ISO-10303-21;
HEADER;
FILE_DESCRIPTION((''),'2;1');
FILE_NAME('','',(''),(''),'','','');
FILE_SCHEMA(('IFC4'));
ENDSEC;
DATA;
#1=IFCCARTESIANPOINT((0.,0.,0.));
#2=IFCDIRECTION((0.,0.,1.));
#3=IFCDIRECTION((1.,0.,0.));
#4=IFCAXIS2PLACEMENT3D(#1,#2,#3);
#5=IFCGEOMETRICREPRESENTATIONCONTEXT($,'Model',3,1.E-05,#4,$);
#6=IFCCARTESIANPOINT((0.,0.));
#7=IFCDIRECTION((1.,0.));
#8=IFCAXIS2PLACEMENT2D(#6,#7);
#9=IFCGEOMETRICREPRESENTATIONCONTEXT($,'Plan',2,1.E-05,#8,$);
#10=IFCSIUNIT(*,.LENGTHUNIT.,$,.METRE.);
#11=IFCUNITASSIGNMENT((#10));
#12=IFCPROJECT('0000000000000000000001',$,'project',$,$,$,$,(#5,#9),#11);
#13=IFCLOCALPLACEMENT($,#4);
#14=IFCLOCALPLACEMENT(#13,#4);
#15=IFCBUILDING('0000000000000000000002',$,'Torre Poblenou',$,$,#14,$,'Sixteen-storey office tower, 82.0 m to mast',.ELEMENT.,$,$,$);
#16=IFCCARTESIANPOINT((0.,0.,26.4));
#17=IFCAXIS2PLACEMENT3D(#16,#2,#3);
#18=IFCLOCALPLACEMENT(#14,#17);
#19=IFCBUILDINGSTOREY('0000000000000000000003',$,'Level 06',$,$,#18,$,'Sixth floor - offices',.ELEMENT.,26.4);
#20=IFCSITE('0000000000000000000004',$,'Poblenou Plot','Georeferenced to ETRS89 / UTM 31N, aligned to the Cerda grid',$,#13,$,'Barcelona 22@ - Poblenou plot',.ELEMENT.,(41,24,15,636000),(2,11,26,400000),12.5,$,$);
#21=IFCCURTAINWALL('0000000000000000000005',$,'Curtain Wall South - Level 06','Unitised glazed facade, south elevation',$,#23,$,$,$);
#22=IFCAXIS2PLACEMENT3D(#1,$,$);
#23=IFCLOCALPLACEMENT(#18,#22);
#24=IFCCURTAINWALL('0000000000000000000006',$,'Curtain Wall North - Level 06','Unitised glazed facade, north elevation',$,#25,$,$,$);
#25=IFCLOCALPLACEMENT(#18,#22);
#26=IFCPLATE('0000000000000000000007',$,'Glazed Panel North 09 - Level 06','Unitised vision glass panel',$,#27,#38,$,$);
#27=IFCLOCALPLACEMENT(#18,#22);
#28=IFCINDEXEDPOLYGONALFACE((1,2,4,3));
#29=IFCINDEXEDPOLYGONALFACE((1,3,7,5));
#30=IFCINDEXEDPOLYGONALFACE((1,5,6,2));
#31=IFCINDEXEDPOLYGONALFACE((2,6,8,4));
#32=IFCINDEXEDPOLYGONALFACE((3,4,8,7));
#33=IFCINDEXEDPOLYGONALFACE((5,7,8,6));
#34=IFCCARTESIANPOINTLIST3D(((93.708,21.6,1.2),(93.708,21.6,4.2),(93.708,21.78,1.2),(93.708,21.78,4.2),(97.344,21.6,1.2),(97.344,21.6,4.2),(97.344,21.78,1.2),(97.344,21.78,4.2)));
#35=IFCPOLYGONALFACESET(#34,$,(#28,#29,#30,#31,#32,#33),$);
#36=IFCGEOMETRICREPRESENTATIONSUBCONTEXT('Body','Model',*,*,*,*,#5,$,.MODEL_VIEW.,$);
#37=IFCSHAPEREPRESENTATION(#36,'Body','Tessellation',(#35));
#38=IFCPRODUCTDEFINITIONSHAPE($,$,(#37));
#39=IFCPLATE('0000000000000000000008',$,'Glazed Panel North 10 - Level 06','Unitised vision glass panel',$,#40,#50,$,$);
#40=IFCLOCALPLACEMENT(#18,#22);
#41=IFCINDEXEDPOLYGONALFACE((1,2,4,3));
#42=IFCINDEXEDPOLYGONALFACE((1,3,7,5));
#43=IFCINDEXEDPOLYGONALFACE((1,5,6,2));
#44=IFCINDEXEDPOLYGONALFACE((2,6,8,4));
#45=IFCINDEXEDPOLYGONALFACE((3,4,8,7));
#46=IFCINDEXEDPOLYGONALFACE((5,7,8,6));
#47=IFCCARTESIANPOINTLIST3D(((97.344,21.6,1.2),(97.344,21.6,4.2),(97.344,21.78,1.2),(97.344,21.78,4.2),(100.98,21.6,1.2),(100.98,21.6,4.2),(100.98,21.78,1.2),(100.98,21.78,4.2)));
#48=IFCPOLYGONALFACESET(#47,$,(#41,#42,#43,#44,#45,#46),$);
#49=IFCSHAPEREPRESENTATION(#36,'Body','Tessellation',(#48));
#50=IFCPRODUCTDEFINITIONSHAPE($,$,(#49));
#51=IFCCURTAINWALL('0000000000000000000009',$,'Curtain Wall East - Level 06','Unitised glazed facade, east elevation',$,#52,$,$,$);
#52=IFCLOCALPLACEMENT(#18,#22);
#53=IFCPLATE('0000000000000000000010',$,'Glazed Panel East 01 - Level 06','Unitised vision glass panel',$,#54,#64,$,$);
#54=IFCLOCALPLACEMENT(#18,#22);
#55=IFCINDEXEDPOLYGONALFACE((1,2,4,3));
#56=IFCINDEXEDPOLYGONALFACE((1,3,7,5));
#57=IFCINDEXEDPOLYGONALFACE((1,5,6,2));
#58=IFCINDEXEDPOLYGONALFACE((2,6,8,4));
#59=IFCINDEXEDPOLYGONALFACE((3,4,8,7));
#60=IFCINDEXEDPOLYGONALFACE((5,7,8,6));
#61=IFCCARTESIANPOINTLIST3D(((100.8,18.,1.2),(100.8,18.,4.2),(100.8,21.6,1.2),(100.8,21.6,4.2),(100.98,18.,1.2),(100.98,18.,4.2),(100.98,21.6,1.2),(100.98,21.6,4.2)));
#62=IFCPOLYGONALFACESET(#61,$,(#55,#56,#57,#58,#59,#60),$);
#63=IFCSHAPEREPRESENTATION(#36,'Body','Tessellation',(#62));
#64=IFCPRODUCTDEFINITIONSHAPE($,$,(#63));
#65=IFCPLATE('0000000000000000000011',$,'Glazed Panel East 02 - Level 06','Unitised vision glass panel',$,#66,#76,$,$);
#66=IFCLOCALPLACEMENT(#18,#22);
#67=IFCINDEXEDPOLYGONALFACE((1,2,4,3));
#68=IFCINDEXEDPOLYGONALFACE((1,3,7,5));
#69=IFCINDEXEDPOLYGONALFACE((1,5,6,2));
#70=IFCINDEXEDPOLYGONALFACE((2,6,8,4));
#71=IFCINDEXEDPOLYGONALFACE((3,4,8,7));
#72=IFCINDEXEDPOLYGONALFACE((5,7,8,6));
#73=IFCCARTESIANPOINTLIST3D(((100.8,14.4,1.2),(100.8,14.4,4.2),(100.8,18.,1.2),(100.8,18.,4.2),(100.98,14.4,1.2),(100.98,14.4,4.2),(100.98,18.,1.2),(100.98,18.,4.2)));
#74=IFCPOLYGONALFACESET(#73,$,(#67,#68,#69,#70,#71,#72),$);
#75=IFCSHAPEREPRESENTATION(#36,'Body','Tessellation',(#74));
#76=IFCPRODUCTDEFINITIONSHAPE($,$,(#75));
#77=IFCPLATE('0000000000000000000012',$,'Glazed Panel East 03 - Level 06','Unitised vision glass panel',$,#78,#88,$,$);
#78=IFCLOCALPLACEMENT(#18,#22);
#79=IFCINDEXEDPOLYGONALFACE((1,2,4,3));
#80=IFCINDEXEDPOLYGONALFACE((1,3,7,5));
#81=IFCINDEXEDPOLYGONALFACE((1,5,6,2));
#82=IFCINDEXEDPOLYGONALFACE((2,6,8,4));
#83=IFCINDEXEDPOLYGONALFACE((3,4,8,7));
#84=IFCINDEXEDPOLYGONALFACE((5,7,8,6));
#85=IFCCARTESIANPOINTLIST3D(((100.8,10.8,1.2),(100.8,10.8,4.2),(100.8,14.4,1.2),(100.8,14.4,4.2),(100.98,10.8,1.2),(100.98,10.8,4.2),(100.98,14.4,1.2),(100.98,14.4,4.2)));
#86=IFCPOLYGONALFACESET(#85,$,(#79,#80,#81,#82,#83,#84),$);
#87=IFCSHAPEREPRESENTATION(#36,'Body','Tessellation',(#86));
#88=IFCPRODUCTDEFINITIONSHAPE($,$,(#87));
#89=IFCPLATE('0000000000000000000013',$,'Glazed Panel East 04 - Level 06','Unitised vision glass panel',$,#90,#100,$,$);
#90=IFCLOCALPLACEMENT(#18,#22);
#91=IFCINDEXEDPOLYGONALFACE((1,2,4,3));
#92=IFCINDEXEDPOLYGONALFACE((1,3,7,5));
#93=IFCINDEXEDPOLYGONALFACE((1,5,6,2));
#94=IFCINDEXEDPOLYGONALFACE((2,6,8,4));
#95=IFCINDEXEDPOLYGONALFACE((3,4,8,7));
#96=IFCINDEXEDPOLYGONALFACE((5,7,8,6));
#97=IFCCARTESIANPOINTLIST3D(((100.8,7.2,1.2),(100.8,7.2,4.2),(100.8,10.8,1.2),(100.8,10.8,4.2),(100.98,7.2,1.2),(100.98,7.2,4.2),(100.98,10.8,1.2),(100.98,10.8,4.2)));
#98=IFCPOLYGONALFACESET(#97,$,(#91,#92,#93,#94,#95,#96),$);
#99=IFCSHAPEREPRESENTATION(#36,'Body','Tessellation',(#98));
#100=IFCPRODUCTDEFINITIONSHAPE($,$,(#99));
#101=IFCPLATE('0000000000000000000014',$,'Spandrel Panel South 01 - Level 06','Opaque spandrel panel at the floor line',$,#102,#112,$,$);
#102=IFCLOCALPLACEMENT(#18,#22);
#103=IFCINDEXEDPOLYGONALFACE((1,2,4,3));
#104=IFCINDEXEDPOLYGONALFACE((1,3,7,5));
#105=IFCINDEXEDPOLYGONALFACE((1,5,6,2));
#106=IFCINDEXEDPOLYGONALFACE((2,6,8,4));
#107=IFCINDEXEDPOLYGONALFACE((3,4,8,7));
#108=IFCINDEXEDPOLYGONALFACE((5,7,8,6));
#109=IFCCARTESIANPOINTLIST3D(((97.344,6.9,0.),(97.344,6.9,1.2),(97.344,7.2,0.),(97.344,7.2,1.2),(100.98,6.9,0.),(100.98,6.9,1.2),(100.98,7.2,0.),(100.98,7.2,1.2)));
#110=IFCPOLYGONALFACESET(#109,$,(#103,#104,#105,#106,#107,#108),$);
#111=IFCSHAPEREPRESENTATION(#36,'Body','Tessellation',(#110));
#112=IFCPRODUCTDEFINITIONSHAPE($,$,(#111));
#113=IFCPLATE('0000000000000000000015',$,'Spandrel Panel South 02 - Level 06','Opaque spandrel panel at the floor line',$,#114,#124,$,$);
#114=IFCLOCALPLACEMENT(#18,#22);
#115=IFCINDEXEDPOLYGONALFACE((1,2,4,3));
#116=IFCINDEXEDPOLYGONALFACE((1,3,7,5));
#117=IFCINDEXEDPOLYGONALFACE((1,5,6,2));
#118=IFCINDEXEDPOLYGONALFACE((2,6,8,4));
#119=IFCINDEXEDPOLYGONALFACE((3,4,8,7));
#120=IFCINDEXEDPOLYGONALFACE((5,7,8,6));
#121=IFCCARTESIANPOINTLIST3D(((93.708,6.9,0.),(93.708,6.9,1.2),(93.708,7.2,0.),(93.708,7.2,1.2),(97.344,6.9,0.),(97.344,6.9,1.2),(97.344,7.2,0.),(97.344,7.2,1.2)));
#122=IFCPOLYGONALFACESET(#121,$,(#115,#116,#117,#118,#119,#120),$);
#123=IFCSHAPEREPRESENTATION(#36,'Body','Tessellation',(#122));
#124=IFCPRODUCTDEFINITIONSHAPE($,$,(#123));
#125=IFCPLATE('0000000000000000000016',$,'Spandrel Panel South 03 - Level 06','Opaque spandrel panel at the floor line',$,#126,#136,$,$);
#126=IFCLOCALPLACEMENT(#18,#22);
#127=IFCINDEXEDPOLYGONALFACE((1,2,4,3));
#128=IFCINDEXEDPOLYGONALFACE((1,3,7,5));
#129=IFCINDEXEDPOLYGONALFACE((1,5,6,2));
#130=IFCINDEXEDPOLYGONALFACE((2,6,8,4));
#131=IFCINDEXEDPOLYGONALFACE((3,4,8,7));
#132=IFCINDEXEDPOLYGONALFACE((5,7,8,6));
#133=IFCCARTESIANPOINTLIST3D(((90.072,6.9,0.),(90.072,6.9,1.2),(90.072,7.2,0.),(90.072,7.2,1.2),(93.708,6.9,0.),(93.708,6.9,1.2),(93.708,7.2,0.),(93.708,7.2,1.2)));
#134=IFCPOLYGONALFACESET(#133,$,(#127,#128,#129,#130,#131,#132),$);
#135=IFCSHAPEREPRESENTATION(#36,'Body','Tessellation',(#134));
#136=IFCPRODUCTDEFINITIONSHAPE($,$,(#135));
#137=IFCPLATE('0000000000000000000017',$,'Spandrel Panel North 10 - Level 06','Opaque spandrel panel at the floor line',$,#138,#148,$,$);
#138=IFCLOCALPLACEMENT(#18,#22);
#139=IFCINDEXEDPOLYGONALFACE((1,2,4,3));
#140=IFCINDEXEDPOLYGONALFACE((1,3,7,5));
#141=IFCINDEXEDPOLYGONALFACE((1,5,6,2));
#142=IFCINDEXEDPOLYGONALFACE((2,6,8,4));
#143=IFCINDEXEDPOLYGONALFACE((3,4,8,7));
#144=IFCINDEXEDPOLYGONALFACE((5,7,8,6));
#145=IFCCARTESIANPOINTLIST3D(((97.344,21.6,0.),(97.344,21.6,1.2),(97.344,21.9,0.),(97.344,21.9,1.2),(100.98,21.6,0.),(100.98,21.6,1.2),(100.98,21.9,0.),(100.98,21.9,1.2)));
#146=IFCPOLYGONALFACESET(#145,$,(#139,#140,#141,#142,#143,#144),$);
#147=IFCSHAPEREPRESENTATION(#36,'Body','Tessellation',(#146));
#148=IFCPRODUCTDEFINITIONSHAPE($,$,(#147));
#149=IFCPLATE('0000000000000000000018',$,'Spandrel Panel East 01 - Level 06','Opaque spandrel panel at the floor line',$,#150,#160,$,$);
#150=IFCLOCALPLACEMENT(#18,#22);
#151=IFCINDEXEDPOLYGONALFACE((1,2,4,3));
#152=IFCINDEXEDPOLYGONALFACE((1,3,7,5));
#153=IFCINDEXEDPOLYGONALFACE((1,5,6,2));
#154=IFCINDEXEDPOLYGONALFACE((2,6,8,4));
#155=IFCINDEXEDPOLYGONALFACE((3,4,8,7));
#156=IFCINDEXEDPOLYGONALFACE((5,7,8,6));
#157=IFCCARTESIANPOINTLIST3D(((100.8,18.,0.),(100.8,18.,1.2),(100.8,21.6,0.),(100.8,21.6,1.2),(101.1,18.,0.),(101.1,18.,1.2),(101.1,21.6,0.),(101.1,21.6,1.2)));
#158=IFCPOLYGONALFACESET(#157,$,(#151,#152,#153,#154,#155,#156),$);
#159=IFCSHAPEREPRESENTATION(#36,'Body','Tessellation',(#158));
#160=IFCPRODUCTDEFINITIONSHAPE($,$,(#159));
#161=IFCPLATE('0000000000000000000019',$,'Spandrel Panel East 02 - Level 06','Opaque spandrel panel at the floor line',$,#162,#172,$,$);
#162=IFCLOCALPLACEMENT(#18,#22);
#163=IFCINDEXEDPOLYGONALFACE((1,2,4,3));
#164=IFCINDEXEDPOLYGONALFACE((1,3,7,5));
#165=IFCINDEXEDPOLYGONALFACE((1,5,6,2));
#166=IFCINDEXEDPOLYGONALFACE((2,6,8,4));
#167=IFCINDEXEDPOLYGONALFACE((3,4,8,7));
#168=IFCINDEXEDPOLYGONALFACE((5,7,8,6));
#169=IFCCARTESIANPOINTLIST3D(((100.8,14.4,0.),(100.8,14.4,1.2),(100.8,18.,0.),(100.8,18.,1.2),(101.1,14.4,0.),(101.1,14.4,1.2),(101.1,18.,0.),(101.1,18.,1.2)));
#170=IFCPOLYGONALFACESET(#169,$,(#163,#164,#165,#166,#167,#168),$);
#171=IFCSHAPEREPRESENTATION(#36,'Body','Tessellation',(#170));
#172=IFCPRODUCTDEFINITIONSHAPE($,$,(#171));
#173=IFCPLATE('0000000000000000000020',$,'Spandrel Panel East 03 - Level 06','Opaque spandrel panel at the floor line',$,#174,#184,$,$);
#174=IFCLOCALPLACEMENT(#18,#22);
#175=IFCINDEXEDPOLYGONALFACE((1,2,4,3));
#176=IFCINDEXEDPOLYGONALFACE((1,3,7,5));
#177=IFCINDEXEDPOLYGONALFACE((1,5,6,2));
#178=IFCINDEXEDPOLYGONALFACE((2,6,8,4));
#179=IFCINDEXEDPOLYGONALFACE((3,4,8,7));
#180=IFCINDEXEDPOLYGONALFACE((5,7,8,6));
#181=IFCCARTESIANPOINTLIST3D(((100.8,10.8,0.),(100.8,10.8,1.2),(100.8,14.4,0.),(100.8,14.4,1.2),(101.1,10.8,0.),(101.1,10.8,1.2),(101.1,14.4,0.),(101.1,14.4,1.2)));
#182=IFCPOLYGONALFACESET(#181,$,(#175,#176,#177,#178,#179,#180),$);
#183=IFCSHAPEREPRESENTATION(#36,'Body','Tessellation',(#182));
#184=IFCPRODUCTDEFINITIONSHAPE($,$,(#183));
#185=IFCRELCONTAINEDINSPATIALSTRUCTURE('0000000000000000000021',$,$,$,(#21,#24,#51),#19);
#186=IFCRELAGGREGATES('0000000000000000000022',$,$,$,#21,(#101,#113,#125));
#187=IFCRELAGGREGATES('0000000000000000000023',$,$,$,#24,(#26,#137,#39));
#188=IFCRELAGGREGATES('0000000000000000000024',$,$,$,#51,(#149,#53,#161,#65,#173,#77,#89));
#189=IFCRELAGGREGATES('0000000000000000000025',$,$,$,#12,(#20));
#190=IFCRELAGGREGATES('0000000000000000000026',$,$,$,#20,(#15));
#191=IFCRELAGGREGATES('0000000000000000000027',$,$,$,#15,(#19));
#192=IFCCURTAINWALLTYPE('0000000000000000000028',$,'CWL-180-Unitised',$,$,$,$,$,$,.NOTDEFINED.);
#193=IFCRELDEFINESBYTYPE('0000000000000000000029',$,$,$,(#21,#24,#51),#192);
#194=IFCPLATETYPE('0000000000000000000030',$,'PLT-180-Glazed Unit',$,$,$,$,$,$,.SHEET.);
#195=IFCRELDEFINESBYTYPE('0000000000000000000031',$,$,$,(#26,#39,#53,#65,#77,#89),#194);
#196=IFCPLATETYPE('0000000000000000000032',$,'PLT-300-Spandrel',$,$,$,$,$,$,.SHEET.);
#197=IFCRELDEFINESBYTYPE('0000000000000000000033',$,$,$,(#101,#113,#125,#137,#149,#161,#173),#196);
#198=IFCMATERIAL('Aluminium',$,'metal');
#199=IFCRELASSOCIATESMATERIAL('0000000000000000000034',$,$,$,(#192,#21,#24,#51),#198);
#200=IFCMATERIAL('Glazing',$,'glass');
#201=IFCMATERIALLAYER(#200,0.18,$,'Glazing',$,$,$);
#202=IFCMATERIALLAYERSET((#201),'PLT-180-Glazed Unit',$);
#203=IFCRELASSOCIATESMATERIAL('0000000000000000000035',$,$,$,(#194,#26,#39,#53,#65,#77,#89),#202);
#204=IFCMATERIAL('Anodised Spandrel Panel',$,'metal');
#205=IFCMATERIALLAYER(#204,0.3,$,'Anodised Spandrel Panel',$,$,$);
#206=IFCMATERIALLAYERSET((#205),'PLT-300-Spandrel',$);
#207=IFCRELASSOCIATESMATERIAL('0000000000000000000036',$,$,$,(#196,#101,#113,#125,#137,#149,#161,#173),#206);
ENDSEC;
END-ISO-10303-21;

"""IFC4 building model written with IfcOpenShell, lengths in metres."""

from ifc_helpers import new_model, si_unit, frame, origin_with_axes, origin_2d_with_axis, place, context, subcontext, project, spatial, line, indexed_curve, outline, extrude, material, layer, layer_set, layer_usage, type_object, element, aggregate, save


model = new_model("IFC4")

# Units and contexts
model_context = context("Model", 3, precision=1e-05, world=origin_with_axes())
plan_context = context("Plan", 2, precision=1e-05, world=origin_2d_with_axis())
body_context = subcontext(model_context, "Body", "Model", "MODEL_VIEW")
ifc_project = project(units=[si_unit("LENGTHUNIT", "METRE")], contexts=[model_context, plan_context])

# Site, building, storey
site_placement = place(None, origin_with_axes())
site = spatial("IfcSite", under=ifc_project, at=site_placement, Name="Poblenou Plot", Description="Georeferenced to ETRS89 / UTM 31N, aligned to the Cerda grid", LongName="Barcelona 22@ - Poblenou plot", CompositionType="ELEMENT", RefLatitude=(41, 24, 15, 636000), RefLongitude=(2, 11, 26, 400000), RefElevation=12.5)
building_placement = place(site_placement, origin_with_axes())
building = spatial("IfcBuilding", under=site, at=building_placement, Name="Torre Poblenou", LongName="Sixteen-storey office tower, 82.0 m to mast", CompositionType="ELEMENT")
storey_placement = place(building_placement, frame((0.0, 0.0, 26.4), z_axis=(0.0, 0.0, 1.0), x_axis=(1.0, 0.0, 0.0)))
storey = spatial("IfcBuildingStorey", under=building, at=storey_placement, Name="Level 06", LongName="Sixth floor - offices", CompositionType="ELEMENT", Elevation=26.4)

# Curtain walls, plates
ifc_material_1 = material(Name="Aluminium", Category="metal")
curtain_wall_type = type_object("IfcCurtainWallType", Name="CWL-180-Unitised", PredefinedType="NOTDEFINED", material=ifc_material_1)
curtain_wall_1_placement = place(storey_placement, frame((100.98, 7.2, 0.0), z_axis=(0.0, 0.0, 1.0), x_axis=(-1.0, 0.0, 0.0)))
curtain_wall_1 = element("IfcCurtainWall", 1, at=curtain_wall_1_placement, inside=storey, type_object=curtain_wall_type, material=ifc_material_1, Name="Curtain Wall South - Level 06", Description="Unitised glazed facade, south elevation")
ifc_material_2 = material(Name="Glazing", Category="glass")
ifc_layer_1 = layer(ifc_material_2, 0.18, Name="Glazing")
ifc_layer_set_1 = layer_set([ifc_layer_1], Name="PLT-180-Glazed Unit")
plate_type_1 = type_object("IfcPlateType", Name="PLT-180-Glazed Unit", PredefinedType="SHEET", material=ifc_layer_set_1)
curtain_wall_2_placement = place(storey_placement, frame((64.62, 21.6, 0.0), z_axis=(0.0, 0.0, 1.0), x_axis=(1.0, 0.0, 0.0)))
curtain_wall_2 = element("IfcCurtainWall", 2, at=curtain_wall_2_placement, inside=storey, type_object=curtain_wall_type, material=ifc_material_1, Name="Curtain Wall North - Level 06", Description="Unitised glazed facade, north elevation")
ifc_layer_usage_1 = layer_usage(ifc_layer_set_1, "AXIS2", "POSITIVE", 0.0)
plate_1_placement = place(curtain_wall_2_placement, frame((29.088, 0.0, 1.2), z_axis=(0.0, 0.0, 1.0), x_axis=(1.0, 0.0, 0.0)))
plate_1 = element("IfcPlate", 3, at=plate_1_placement, type_object=plate_type_1, material=ifc_layer_usage_1, Name="Glazed Panel North 09 - Level 06", Description="Unitised vision glass panel", context=body_context, shape_type="SweptSolid", body=[
    extrude(outline(indexed_curve([(0.0, 0.0), (3.636, 0.0), (3.636, 0.18), (0.0, 0.18)], segments=[line(1, 2, 3, 4, 1)])), origin_with_axes(), (0.0, 0.0, 1.0), 3.0),
])
ifc_layer_usage_2 = layer_usage(ifc_layer_set_1, "AXIS2", "POSITIVE", 0.0)
plate_2_placement = place(curtain_wall_2_placement, frame((32.724, 0.0, 1.2), z_axis=(0.0, 0.0, 1.0), x_axis=(1.0, 0.0, 0.0)))
plate_2 = element("IfcPlate", 4, at=plate_2_placement, type_object=plate_type_1, material=ifc_layer_usage_2, Name="Glazed Panel North 10 - Level 06", Description="Unitised vision glass panel", context=body_context, shape_type="SweptSolid", body=[
    extrude(outline(indexed_curve([(0.0, 0.0), (3.636, 0.0), (3.636, 0.18), (0.0, 0.18)], segments=[line(1, 2, 3, 4, 1)])), origin_with_axes(), (0.0, 0.0, 1.0), 3.0),
])
curtain_wall_3_placement = place(storey_placement, frame((100.8, 21.6, 0.0), z_axis=(0.0, 0.0, 1.0), x_axis=(0.0, -1.0, 0.0)))
curtain_wall_3 = element("IfcCurtainWall", 5, at=curtain_wall_3_placement, inside=storey, type_object=curtain_wall_type, material=ifc_material_1, Name="Curtain Wall East - Level 06", Description="Unitised glazed facade, east elevation")
ifc_layer_usage_3 = layer_usage(ifc_layer_set_1, "AXIS2", "POSITIVE", 0.0)
plate_3_placement = place(curtain_wall_3_placement, frame((0.0, 0.0, 1.2), z_axis=(0.0, 0.0, 1.0), x_axis=(1.0, 0.0, 0.0)))
plate_3 = element("IfcPlate", 6, at=plate_3_placement, type_object=plate_type_1, material=ifc_layer_usage_3, Name="Glazed Panel East 01 - Level 06", Description="Unitised vision glass panel", context=body_context, shape_type="SweptSolid", body=[
    extrude(outline(indexed_curve([(0.0, 0.0), (3.6, 0.0), (3.6, 0.18), (0.0, 0.18)], segments=[line(1, 2, 3, 4, 1)])), origin_with_axes(), (0.0, 0.0, 1.0), 3.0),
])
ifc_layer_usage_4 = layer_usage(ifc_layer_set_1, "AXIS2", "POSITIVE", 0.0)
plate_4_placement = place(curtain_wall_3_placement, frame((3.6, 0.0, 1.2), z_axis=(0.0, 0.0, 1.0), x_axis=(1.0, 0.0, 0.0)))
plate_4 = element("IfcPlate", 7, at=plate_4_placement, type_object=plate_type_1, material=ifc_layer_usage_4, Name="Glazed Panel East 02 - Level 06", Description="Unitised vision glass panel", context=body_context, shape_type="SweptSolid", body=[
    extrude(outline(indexed_curve([(0.0, 0.0), (3.6, 0.0), (3.6, 0.18), (0.0, 0.18)], segments=[line(1, 2, 3, 4, 1)])), origin_with_axes(), (0.0, 0.0, 1.0), 3.0),
])
ifc_layer_usage_5 = layer_usage(ifc_layer_set_1, "AXIS2", "POSITIVE", 0.0)
plate_5_placement = place(curtain_wall_3_placement, frame((7.2, 0.0, 1.2), z_axis=(0.0, 0.0, 1.0), x_axis=(1.0, 0.0, 0.0)))
plate_5 = element("IfcPlate", 8, at=plate_5_placement, type_object=plate_type_1, material=ifc_layer_usage_5, Name="Glazed Panel East 03 - Level 06", Description="Unitised vision glass panel", context=body_context, shape_type="SweptSolid", body=[
    extrude(outline(indexed_curve([(0.0, 0.0), (3.6, 0.0), (3.6, 0.18), (0.0, 0.18)], segments=[line(1, 2, 3, 4, 1)])), origin_with_axes(), (0.0, 0.0, 1.0), 3.0),
])
ifc_layer_usage_6 = layer_usage(ifc_layer_set_1, "AXIS2", "POSITIVE", 0.0)
plate_6_placement = place(curtain_wall_3_placement, frame((10.8, 0.0, 1.2), z_axis=(0.0, 0.0, 1.0), x_axis=(1.0, 0.0, 0.0)))
plate_6 = element("IfcPlate", 9, at=plate_6_placement, type_object=plate_type_1, material=ifc_layer_usage_6, Name="Glazed Panel East 04 - Level 06", Description="Unitised vision glass panel", context=body_context, shape_type="SweptSolid", body=[
    extrude(outline(indexed_curve([(0.0, 0.0), (3.6, 0.0), (3.6, 0.18), (0.0, 0.18)], segments=[line(1, 2, 3, 4, 1)])), origin_with_axes(), (0.0, 0.0, 1.0), 3.0),
])

# Plates
ifc_material_3 = material(Name="Anodised Spandrel Panel", Category="metal")
ifc_layer_2 = layer(ifc_material_3, 0.3, Name="Anodised Spandrel Panel")
ifc_layer_set_2 = layer_set([ifc_layer_2], Name="PLT-300-Spandrel")
ifc_layer_usage_7 = layer_usage(ifc_layer_set_2, "AXIS2", "POSITIVE", 0.0)
plate_type_2 = type_object("IfcPlateType", Name="PLT-300-Spandrel", PredefinedType="SHEET", material=ifc_layer_set_2)
plate_7_placement = place(curtain_wall_1_placement, origin_with_axes())
plate_7 = element("IfcPlate", 10, at=plate_7_placement, type_object=plate_type_2, material=ifc_layer_usage_7, Name="Spandrel Panel South 01 - Level 06", Description="Opaque spandrel panel at the floor line", context=body_context, shape_type="SweptSolid", body=[
    extrude(outline(indexed_curve([(0.0, 0.0), (3.636, 0.0), (3.636, 0.3), (0.0, 0.3)], segments=[line(1, 2, 3, 4, 1)])), origin_with_axes(), (0.0, 0.0, 1.0), 1.2),
])
ifc_layer_usage_8 = layer_usage(ifc_layer_set_2, "AXIS2", "POSITIVE", 0.0)
plate_8_placement = place(curtain_wall_1_placement, frame((3.636, 0.0, 0.0), z_axis=(0.0, 0.0, 1.0), x_axis=(1.0, 0.0, 0.0)))
plate_8 = element("IfcPlate", 11, at=plate_8_placement, type_object=plate_type_2, material=ifc_layer_usage_8, Name="Spandrel Panel South 02 - Level 06", Description="Opaque spandrel panel at the floor line", context=body_context, shape_type="SweptSolid", body=[
    extrude(outline(indexed_curve([(0.0, 0.0), (3.636, 0.0), (3.636, 0.3), (0.0, 0.3)], segments=[line(1, 2, 3, 4, 1)])), origin_with_axes(), (0.0, 0.0, 1.0), 1.2),
])
ifc_layer_usage_9 = layer_usage(ifc_layer_set_2, "AXIS2", "POSITIVE", 0.0)
plate_9_placement = place(curtain_wall_1_placement, frame((7.272, 0.0, 0.0), z_axis=(0.0, 0.0, 1.0), x_axis=(1.0, 0.0, 0.0)))
plate_9 = element("IfcPlate", 12, at=plate_9_placement, type_object=plate_type_2, material=ifc_layer_usage_9, Name="Spandrel Panel South 03 - Level 06", Description="Opaque spandrel panel at the floor line", context=body_context, shape_type="SweptSolid", body=[
    extrude(outline(indexed_curve([(0.0, 0.0), (3.636, 0.0), (3.636, 0.3), (0.0, 0.3)], segments=[line(1, 2, 3, 4, 1)])), origin_with_axes(), (0.0, 0.0, 1.0), 1.2),
])
aggregate(curtain_wall_1, [plate_7, plate_8, plate_9])
ifc_layer_usage_10 = layer_usage(ifc_layer_set_2, "AXIS2", "POSITIVE", 0.0)
plate_10_placement = place(curtain_wall_2_placement, frame((32.724, 0.0, 0.0), z_axis=(0.0, 0.0, 1.0), x_axis=(1.0, 0.0, 0.0)))
plate_10 = element("IfcPlate", 13, at=plate_10_placement, type_object=plate_type_2, material=ifc_layer_usage_10, Name="Spandrel Panel North 10 - Level 06", Description="Opaque spandrel panel at the floor line", context=body_context, shape_type="SweptSolid", body=[
    extrude(outline(indexed_curve([(0.0, 0.0), (3.636, 0.0), (3.636, 0.3), (0.0, 0.3)], segments=[line(1, 2, 3, 4, 1)])), origin_with_axes(), (0.0, 0.0, 1.0), 1.2),
])
aggregate(curtain_wall_2, [plate_1, plate_10, plate_2])
ifc_layer_usage_11 = layer_usage(ifc_layer_set_2, "AXIS2", "POSITIVE", 0.0)
plate_11_placement = place(curtain_wall_3_placement, origin_with_axes())
plate_11 = element("IfcPlate", 14, at=plate_11_placement, type_object=plate_type_2, material=ifc_layer_usage_11, Name="Spandrel Panel East 01 - Level 06", Description="Opaque spandrel panel at the floor line", context=body_context, shape_type="SweptSolid", body=[
    extrude(outline(indexed_curve([(0.0, 0.0), (3.6, 0.0), (3.6, 0.3), (0.0, 0.3)], segments=[line(1, 2, 3, 4, 1)])), origin_with_axes(), (0.0, 0.0, 1.0), 1.2),
])
ifc_layer_usage_12 = layer_usage(ifc_layer_set_2, "AXIS2", "POSITIVE", 0.0)
plate_12_placement = place(curtain_wall_3_placement, frame((3.6, 0.0, 0.0), z_axis=(0.0, 0.0, 1.0), x_axis=(1.0, 0.0, 0.0)))
plate_12 = element("IfcPlate", 15, at=plate_12_placement, type_object=plate_type_2, material=ifc_layer_usage_12, Name="Spandrel Panel East 02 - Level 06", Description="Opaque spandrel panel at the floor line", context=body_context, shape_type="SweptSolid", body=[
    extrude(outline(indexed_curve([(0.0, 0.0), (3.6, 0.0), (3.6, 0.3), (0.0, 0.3)], segments=[line(1, 2, 3, 4, 1)])), origin_with_axes(), (0.0, 0.0, 1.0), 1.2),
])
ifc_layer_usage_13 = layer_usage(ifc_layer_set_2, "AXIS2", "POSITIVE", 0.0)
plate_13_placement = place(curtain_wall_3_placement, frame((7.2, 0.0, 0.0), z_axis=(0.0, 0.0, 1.0), x_axis=(1.0, 0.0, 0.0)))
plate_13 = element("IfcPlate", 16, at=plate_13_placement, type_object=plate_type_2, material=ifc_layer_usage_13, Name="Spandrel Panel East 03 - Level 06", Description="Opaque spandrel panel at the floor line", context=body_context, shape_type="SweptSolid", body=[
    extrude(outline(indexed_curve([(0.0, 0.0), (3.6, 0.0), (3.6, 0.3), (0.0, 0.3)], segments=[line(1, 2, 3, 4, 1)])), origin_with_axes(), (0.0, 0.0, 1.0), 1.2),
])
aggregate(curtain_wall_3, [plate_11, plate_3, plate_12, plate_4, plate_13, plate_5, plate_6])

save(model, "model.ifc")
